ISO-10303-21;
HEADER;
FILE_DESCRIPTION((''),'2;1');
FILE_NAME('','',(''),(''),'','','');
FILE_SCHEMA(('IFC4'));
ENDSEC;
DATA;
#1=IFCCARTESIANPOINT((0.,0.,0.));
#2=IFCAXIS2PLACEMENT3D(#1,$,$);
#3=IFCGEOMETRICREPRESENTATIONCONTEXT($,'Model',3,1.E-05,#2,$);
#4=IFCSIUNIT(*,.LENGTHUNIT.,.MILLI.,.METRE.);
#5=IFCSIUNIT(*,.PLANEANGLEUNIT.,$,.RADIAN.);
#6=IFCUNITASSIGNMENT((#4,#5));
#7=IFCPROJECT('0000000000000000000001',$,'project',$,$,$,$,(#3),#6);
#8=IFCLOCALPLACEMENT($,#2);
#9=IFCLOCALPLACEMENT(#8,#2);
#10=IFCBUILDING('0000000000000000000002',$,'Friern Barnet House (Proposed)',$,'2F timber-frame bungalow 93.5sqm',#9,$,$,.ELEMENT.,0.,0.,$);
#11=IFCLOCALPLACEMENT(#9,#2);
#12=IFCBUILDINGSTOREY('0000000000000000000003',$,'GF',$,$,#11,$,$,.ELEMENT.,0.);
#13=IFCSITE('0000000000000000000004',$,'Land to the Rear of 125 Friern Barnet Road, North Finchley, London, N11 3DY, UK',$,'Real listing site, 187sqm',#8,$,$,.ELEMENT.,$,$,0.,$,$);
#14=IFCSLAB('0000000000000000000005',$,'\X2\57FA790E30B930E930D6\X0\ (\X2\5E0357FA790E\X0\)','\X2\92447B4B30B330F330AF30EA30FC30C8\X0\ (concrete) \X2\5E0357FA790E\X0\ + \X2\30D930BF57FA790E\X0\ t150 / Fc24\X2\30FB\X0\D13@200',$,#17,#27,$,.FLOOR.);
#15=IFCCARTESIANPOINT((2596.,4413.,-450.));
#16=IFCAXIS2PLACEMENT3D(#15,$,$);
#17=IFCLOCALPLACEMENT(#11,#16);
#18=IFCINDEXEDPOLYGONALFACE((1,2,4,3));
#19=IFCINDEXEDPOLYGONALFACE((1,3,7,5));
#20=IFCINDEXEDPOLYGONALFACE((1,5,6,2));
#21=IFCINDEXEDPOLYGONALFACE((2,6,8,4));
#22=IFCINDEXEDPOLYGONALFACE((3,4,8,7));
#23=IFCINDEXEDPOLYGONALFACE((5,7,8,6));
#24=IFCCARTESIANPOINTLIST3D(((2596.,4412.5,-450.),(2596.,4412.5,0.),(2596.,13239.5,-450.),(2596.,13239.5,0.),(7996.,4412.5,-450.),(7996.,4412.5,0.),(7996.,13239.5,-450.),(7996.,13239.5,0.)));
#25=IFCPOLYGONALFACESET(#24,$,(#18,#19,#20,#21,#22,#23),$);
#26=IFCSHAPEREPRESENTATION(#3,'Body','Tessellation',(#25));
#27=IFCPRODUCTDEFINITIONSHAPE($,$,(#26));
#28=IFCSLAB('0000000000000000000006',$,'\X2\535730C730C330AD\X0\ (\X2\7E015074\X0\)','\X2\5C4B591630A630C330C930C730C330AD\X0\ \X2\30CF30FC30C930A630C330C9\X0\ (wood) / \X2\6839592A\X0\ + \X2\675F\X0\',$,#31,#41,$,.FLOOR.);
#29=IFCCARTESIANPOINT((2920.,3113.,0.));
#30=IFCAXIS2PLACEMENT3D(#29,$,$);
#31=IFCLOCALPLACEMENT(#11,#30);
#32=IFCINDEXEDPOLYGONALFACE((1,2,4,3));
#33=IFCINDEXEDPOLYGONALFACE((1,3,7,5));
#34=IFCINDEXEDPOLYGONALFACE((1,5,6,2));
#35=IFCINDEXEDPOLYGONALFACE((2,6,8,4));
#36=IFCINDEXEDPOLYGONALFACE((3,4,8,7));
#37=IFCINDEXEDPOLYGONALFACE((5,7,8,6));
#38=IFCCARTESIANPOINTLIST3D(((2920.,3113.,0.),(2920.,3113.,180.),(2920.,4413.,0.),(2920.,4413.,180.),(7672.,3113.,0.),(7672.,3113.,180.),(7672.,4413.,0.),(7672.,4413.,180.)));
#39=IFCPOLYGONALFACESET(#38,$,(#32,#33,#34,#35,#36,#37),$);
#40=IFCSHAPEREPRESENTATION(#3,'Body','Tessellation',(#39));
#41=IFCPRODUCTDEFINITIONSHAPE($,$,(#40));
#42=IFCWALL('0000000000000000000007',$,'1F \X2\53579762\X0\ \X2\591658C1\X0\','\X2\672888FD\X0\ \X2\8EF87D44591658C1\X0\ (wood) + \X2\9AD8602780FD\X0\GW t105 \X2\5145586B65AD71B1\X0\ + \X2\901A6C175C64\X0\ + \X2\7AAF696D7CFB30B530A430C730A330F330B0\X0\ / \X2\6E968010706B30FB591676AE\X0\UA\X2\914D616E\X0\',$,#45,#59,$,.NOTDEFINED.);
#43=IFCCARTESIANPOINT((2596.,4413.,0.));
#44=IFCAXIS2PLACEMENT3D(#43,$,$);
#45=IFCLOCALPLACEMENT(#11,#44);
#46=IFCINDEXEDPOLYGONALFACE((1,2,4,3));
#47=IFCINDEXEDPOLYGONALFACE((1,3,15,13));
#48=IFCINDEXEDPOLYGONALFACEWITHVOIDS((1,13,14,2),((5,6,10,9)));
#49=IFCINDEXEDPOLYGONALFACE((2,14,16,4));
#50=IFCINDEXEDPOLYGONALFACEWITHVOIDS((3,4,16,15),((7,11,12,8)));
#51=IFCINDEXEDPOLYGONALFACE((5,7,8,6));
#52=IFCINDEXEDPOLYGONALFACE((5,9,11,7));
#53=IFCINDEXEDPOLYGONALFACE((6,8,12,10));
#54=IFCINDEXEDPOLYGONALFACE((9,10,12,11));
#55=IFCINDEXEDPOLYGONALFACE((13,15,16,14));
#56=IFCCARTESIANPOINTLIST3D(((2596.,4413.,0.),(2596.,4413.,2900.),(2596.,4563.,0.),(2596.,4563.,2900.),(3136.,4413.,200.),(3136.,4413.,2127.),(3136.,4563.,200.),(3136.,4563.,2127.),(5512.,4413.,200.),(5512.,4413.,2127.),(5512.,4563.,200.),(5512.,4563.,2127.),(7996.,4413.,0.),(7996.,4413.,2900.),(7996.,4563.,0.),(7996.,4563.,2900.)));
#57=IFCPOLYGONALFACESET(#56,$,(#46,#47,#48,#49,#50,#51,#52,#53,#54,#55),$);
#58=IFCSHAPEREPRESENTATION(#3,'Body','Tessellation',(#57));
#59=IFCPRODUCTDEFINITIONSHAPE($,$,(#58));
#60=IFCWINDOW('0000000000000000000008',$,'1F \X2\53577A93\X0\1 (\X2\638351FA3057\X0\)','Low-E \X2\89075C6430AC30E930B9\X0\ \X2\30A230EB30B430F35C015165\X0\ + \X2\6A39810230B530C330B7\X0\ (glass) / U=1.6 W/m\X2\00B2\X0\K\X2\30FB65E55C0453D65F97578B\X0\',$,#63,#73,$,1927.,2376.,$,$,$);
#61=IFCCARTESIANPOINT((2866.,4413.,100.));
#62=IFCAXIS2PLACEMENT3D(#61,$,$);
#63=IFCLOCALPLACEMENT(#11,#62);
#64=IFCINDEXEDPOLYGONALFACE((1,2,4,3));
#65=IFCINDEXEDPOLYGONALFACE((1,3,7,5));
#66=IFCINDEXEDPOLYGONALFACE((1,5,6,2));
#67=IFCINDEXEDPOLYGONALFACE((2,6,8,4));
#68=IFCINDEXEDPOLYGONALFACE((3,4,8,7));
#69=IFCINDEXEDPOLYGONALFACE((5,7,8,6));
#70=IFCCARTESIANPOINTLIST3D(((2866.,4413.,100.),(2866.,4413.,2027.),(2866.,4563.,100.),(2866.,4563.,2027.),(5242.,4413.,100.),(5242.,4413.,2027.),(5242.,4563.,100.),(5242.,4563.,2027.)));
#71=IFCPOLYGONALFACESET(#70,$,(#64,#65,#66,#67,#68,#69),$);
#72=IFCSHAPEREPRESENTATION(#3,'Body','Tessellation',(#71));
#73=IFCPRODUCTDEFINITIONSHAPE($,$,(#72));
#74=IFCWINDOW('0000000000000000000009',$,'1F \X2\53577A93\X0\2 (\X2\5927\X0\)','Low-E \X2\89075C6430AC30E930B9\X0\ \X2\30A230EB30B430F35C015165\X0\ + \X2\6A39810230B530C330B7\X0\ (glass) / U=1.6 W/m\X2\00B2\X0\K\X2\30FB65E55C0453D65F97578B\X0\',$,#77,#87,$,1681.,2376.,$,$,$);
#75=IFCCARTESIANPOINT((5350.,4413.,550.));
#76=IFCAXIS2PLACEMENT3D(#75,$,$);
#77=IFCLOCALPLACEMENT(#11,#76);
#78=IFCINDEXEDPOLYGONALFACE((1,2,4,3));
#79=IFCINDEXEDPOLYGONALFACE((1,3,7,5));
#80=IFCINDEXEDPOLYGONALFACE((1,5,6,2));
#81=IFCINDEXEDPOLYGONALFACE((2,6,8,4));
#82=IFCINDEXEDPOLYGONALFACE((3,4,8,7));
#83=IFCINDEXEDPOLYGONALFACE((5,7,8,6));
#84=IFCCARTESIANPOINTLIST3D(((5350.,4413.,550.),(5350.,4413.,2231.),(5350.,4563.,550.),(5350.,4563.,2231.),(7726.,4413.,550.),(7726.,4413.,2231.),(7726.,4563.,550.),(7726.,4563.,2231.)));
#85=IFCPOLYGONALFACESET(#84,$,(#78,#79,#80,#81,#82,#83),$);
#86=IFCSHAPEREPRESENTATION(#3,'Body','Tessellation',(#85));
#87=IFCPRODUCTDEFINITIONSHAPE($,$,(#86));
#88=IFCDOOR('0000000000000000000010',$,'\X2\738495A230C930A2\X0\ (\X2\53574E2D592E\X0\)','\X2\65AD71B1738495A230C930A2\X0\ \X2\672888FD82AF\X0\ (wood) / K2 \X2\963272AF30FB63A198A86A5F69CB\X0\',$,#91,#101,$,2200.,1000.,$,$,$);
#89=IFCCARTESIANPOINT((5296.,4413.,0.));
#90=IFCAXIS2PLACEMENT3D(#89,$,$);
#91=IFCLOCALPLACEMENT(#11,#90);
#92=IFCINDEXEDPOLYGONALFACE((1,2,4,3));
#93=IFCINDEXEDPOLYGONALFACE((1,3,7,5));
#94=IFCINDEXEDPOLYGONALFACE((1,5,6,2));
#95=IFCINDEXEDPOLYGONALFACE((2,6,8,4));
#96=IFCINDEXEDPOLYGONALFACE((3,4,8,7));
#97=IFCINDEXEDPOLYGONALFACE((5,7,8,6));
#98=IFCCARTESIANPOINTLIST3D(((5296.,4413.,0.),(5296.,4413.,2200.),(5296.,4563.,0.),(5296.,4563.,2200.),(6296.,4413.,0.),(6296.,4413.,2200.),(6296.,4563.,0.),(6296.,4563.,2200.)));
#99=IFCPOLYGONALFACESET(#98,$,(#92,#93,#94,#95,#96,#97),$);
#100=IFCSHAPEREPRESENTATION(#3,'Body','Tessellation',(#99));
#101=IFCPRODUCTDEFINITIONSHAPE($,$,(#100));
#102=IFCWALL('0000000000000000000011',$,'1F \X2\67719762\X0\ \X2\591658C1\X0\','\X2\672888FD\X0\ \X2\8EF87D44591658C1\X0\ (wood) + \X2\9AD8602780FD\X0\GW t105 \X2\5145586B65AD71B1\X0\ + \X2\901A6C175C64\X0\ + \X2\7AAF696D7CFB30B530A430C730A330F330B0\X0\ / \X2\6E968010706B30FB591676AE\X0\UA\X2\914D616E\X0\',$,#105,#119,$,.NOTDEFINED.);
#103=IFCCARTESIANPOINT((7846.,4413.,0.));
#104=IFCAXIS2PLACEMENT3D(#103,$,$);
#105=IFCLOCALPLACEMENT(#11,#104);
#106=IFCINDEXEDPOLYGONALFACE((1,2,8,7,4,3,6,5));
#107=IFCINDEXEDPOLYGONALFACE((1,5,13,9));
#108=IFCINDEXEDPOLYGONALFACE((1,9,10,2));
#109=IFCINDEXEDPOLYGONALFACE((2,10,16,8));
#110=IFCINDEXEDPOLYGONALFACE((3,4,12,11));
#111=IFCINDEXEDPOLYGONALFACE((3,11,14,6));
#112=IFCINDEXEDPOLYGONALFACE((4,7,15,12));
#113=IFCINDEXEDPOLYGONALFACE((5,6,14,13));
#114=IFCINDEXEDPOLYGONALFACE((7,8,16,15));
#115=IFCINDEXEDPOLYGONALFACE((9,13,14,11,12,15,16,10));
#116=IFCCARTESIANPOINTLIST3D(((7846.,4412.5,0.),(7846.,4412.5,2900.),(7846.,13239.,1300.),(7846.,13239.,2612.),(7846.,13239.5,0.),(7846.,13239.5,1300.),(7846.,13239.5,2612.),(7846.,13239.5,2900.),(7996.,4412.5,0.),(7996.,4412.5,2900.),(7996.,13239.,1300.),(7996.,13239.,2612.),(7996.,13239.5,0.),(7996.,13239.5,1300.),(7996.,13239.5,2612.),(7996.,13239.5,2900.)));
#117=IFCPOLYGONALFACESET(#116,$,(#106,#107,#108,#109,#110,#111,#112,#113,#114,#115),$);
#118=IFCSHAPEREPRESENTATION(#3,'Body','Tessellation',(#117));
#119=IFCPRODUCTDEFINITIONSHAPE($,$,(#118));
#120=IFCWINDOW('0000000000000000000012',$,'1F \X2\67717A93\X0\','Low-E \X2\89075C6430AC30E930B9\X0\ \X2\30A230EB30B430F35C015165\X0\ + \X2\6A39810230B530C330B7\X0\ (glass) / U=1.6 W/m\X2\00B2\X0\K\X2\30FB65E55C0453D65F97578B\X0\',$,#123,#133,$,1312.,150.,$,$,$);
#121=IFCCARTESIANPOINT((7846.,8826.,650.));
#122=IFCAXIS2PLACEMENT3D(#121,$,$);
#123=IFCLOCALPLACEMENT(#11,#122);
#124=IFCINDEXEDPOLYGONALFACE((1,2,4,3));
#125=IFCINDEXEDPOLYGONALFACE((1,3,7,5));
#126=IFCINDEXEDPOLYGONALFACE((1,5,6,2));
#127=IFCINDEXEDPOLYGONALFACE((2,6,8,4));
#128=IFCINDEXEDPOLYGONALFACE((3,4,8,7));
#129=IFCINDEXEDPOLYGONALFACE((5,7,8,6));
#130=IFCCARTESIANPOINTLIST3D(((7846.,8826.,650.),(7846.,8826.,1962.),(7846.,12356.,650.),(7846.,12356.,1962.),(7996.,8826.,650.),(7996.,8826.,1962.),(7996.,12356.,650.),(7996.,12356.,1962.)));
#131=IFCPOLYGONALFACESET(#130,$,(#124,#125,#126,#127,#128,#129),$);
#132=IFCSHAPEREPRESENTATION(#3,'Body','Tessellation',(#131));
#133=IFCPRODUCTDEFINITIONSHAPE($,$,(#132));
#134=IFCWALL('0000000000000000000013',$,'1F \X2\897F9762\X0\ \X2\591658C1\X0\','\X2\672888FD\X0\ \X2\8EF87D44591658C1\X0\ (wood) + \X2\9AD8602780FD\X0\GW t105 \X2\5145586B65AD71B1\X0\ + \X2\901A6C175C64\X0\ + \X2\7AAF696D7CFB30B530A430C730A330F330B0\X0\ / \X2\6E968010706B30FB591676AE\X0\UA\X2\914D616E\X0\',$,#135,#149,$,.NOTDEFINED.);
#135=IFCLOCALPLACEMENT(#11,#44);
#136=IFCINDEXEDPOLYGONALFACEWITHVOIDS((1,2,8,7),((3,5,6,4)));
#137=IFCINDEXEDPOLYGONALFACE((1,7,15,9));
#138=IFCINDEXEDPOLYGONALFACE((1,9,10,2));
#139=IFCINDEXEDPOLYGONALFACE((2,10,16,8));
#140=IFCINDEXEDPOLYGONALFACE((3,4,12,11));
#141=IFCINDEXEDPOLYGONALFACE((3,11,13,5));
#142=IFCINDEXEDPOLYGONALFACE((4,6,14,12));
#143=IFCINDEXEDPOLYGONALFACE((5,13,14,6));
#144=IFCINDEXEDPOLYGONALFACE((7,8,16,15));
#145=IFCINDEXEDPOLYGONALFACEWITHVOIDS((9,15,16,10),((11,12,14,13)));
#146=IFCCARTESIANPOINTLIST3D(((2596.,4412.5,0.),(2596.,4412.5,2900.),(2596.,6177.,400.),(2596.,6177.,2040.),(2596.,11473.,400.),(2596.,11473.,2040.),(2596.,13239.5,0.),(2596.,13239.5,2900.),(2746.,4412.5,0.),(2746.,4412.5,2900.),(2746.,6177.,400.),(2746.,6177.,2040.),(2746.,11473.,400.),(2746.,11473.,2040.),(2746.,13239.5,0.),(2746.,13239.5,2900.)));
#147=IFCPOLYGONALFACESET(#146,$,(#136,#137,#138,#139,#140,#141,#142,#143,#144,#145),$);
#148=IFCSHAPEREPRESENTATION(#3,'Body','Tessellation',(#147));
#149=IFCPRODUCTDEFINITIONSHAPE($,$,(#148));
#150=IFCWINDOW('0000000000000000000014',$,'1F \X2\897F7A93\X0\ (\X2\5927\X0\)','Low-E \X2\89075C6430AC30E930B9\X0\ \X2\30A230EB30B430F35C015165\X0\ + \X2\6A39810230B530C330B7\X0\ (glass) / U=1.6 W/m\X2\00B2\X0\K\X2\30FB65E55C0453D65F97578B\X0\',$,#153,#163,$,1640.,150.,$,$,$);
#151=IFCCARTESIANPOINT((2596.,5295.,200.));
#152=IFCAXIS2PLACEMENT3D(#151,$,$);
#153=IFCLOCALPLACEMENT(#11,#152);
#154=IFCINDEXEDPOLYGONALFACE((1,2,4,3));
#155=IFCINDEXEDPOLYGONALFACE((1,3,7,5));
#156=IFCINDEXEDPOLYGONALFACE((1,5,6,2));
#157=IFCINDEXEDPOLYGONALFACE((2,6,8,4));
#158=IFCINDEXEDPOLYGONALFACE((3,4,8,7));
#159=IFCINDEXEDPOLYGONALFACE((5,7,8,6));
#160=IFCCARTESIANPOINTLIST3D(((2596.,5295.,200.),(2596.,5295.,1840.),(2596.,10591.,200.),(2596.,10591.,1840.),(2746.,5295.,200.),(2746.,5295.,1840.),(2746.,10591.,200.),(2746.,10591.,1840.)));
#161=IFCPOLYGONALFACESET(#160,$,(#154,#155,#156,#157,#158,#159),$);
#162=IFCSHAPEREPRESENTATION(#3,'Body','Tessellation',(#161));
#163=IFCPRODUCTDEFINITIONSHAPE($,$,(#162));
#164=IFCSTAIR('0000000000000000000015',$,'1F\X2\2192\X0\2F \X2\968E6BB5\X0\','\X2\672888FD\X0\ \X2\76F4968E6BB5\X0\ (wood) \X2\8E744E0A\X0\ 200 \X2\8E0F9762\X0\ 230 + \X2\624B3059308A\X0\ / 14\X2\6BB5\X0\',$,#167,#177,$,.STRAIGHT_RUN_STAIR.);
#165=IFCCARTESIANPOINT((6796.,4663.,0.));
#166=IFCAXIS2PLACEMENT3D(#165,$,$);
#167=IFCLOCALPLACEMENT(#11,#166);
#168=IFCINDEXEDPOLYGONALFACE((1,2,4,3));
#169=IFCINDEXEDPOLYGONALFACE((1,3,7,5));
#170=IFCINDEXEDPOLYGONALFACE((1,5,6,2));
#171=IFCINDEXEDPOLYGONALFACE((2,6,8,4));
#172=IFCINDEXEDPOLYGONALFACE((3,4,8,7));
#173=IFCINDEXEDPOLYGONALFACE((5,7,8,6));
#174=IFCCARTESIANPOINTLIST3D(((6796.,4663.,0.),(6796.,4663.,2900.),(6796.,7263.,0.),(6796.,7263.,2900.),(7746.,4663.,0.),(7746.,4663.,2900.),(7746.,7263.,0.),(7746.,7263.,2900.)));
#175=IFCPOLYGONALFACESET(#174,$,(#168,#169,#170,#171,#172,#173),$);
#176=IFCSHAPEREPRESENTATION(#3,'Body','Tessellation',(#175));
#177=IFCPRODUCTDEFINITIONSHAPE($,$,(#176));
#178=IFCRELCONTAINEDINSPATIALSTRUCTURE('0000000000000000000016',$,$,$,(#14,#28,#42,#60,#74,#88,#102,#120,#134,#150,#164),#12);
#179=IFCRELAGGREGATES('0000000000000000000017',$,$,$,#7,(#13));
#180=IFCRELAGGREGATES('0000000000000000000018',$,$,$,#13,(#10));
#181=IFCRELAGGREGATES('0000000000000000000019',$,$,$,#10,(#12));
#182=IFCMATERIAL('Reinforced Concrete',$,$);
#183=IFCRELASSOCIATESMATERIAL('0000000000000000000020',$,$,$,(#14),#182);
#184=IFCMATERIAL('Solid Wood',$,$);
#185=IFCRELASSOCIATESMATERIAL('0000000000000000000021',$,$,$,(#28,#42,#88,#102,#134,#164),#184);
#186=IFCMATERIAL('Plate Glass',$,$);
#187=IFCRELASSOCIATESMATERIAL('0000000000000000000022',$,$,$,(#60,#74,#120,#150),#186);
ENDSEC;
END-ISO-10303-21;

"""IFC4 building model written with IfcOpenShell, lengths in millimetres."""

from ifc_helpers import new_model, si_unit, frame, frame_2d, origin, place, context, project, spatial, rectangle, extrude, material, element, fill, save


model = new_model("IFC4")

# Units and contexts
model_context = context("Model", 3, precision=1e-05, world=origin())
ifc_project = project(units=[si_unit("LENGTHUNIT", "METRE", prefix="MILLI"), si_unit("PLANEANGLEUNIT", "RADIAN")], contexts=[model_context])

# Site, building, storey
site_placement = place(None, origin())
site = spatial("IfcSite", under=ifc_project, at=site_placement, Name="Land to the Rear of 125 Friern Barnet Road, North Finchley, London, N11 3DY, UK", ObjectType="Real listing site, 187sqm", CompositionType="ELEMENT", RefElevation=0.0)
building_placement = place(site_placement, origin())
building = spatial("IfcBuilding", under=site, at=building_placement, Name="Friern Barnet House (Proposed)", ObjectType="2F timber-frame bungalow 93.5sqm", CompositionType="ELEMENT", ElevationOfRefHeight=0.0, ElevationOfTerrain=0.0)
storey_placement = place(building_placement, origin())
storey = spatial("IfcBuildingStorey", under=building, at=storey_placement, Name="GF", CompositionType="ELEMENT", Elevation=0.0)

# Slabs
ifc_material_1 = material(Name="Reinforced Concrete")
slab_1_placement = place(storey_placement, frame((2596.0, 4413.0, -450.0)))
element("IfcSlab", 1, at=slab_1_placement, inside=storey, material=ifc_material_1, Name="基礎スラブ (布基礎)", Description="鉄筋コンクリート (concrete) 布基礎 + ベタ基礎 t150 / Fc24・D13@200", PredefinedType="FLOOR", context=model_context, shape_type="SweptSolid", body=[
    extrude(rectangle(XDim=5400.0, YDim=8827.0, at=frame_2d((2700.0, 4413.0))), frame((2596.0, 4413.0, -450.0)), (0.0, 0.0, 1.0), 450.0),
])
ifc_material_2 = material(Name="Solid Wood")
slab_2_placement = place(storey_placement, frame((2920.0, 3113.0, 0.0)))
element("IfcSlab", 2, at=slab_2_placement, inside=storey, material=ifc_material_2, Name="南デッキ (縁側)", Description="屋外ウッドデッキ ハードウッド (wood) / 根太 + 束", PredefinedType="FLOOR", context=model_context, shape_type="SweptSolid", body=[
    extrude(rectangle(XDim=4752.0, YDim=1300.0, at=frame_2d((2376.0, 650.0))), frame((2920.0, 3113.0, 0.0)), (0.0, 0.0, 1.0), 180.0),
])

# Wall, openings, windows, door
wall_1_placement = place(storey_placement, frame((2596.0, 4413.0, 0.0)))
wall_1 = element("IfcWall", 3, at=wall_1_placement, inside=storey, material=ifc_material_2, Name="1F 南面 外壁", Description="木製 軸組外壁 (wood) + 高性能GW t105 充填断熱 + 通気層 + 窯業系サイディング / 準耐火・外皮UA配慮", PredefinedType="NOTDEFINED", context=model_context, shape_type="SweptSolid", body=[
    extrude(rectangle(XDim=5400.0, YDim=150.0, at=frame_2d((2700.0, 75.0))), frame((2596.0, 4413.0, 0.0)), (0.0, 0.0, 1.0), 2900.0),
])
opening_1_placement = place(storey_placement, frame((2866.0, 4413.0, 100.0)))
opening_1 = element("IfcOpeningElement", 4, at=opening_1_placement, cuts=wall_1, PredefinedType="NOTDEFINED", context=model_context, shape_type="SweptSolid", body=[
    extrude(rectangle(XDim=2376.0, YDim=150.0, at=frame_2d((1188.0, 75.0))), frame((2866.0, 4413.0, 100.0)), (0.0, 0.0, 1.0), 1927.0),
])
opening_2_placement = place(storey_placement, frame((5350.0, 4413.0, 550.0)))
opening_2 = element("IfcOpeningElement", 5, at=opening_2_placement, cuts=wall_1, PredefinedType="NOTDEFINED", context=model_context, shape_type="SweptSolid", body=[
    extrude(rectangle(XDim=2376.0, YDim=150.0, at=frame_2d((1188.0, 75.0))), frame((5350.0, 4413.0, 550.0)), (0.0, 0.0, 1.0), 1681.0),
])
opening_3_placement = place(storey_placement, frame((5296.0, 4413.0, 0.0)))
opening_3 = element("IfcOpeningElement", 6, at=opening_3_placement, cuts=wall_1, PredefinedType="NOTDEFINED", context=model_context, shape_type="SweptSolid", body=[
    extrude(rectangle(XDim=1000.0, YDim=150.0, at=frame_2d((500.0, 75.0))), frame((5296.0, 4413.0, 0.0)), (0.0, 0.0, 1.0), 2200.0),
])
ifc_material_3 = material(Name="Plate Glass")
window_1_placement = place(storey_placement, frame((2866.0, 4413.0, 100.0)))
window_1 = element("IfcWindow", 7, at=window_1_placement, inside=storey, material=ifc_material_3, Name="1F 南窓1 (掃出し)", Description="Low-E 複層ガラス アルゴン封入 + 樹脂サッシ (glass) / U=1.6 W/m²K・日射取得型", OverallHeight=1927.0, OverallWidth=2376.0, context=model_context, shape_type="SweptSolid", body=[
    extrude(rectangle(XDim=2376.0, YDim=150.0, at=frame_2d((1188.0, 75.0))), frame((2866.0, 4413.0, 100.0)), (0.0, 0.0, 1.0), 1927.0),
])
fill(opening_1, window_1)
window_2_placement = place(storey_placement, frame((5350.0, 4413.0, 550.0)))
window_2 = element("IfcWindow", 8, at=window_2_placement, inside=storey, material=ifc_material_3, Name="1F 南窓2 (大)", Description="Low-E 複層ガラス アルゴン封入 + 樹脂サッシ (glass) / U=1.6 W/m²K・日射取得型", OverallHeight=1681.0, OverallWidth=2376.0, context=model_context, shape_type="SweptSolid", body=[
    extrude(rectangle(XDim=2376.0, YDim=150.0, at=frame_2d((1188.0, 75.0))), frame((5350.0, 4413.0, 550.0)), (0.0, 0.0, 1.0), 1681.0),
])
fill(opening_2, window_2)
door_placement = place(storey_placement, frame((5296.0, 4413.0, 0.0)))
door = element("IfcDoor", 9, at=door_placement, inside=storey, material=ifc_material_2, Name="玄関ドア (南中央)", Description="断熱玄関ドア 木製芯 (wood) / K2 防犯・採風機構", OverallHeight=2200.0, OverallWidth=1000.0, context=model_context, shape_type="SweptSolid", body=[
    extrude(rectangle(XDim=1000.0, YDim=150.0, at=frame_2d((500.0, 75.0))), frame((5296.0, 4413.0, 0.0)), (0.0, 0.0, 1.0), 2200.0),
])
fill(opening_3, door)

# Walls, openings, windows
wall_2_placement = place(storey_placement, frame((7846.0, 4413.0, 0.0)))
wall_2 = element("IfcWall", 10, at=wall_2_placement, inside=storey, material=ifc_material_2, Name="1F 東面 外壁", Description="木製 軸組外壁 (wood) + 高性能GW t105 充填断熱 + 通気層 + 窯業系サイディング / 準耐火・外皮UA配慮", PredefinedType="NOTDEFINED", context=model_context, shape_type="SweptSolid", body=[
    extrude(rectangle(XDim=150.0, YDim=8827.0, at=frame_2d((75.0, 4413.0))), frame((7846.0, 4413.0, 0.0)), (0.0, 0.0, 1.0), 2900.0),
])
opening_4_placement = place(storey_placement, frame((7846.0, 8826.0, 650.0)))
opening_4 = element("IfcOpeningElement", 11, at=opening_4_placement, cuts=wall_2, PredefinedType="NOTDEFINED", context=model_context, shape_type="SweptSolid", body=[
    extrude(rectangle(XDim=150.0, YDim=3530.0, at=frame_2d((75.0, 1765.0))), frame((7846.0, 8826.0, 650.0)), (0.0, 0.0, 1.0), 1312.0),
])
window_3_placement = place(storey_placement, frame((7846.0, 8826.0, 650.0)))
window_3 = element("IfcWindow", 12, at=window_3_placement, inside=storey, material=ifc_material_3, Name="1F 東窓", Description="Low-E 複層ガラス アルゴン封入 + 樹脂サッシ (glass) / U=1.6 W/m²K・日射取得型", OverallHeight=1312.0, OverallWidth=150.0, context=model_context, shape_type="SweptSolid", body=[
    extrude(rectangle(XDim=150.0, YDim=3530.0, at=frame_2d((75.0, 1765.0))), frame((7846.0, 8826.0, 650.0)), (0.0, 0.0, 1.0), 1312.0),
])
fill(opening_4, window_3)
wall_3_placement = place(storey_placement, frame((2596.0, 4413.0, 0.0)))
wall_3 = element("IfcWall", 13, at=wall_3_placement, inside=storey, material=ifc_material_2, Name="1F 西面 外壁", Description="木製 軸組外壁 (wood) + 高性能GW t105 充填断熱 + 通気層 + 窯業系サイディング / 準耐火・外皮UA配慮", PredefinedType="NOTDEFINED", context=model_context, shape_type="SweptSolid", body=[
    extrude(rectangle(XDim=150.0, YDim=8827.0, at=frame_2d((75.0, 4413.0))), frame((2596.0, 4413.0, 0.0)), (0.0, 0.0, 1.0), 2900.0),
])
opening_5_placement = place(storey_placement, frame((2596.0, 5295.0, 200.0)))
opening_5 = element("IfcOpeningElement", 14, at=opening_5_placement, cuts=wall_3, PredefinedType="NOTDEFINED", context=model_context, shape_type="SweptSolid", body=[
    extrude(rectangle(XDim=150.0, YDim=5296.0, at=frame_2d((75.0, 2648.0))), frame((2596.0, 5295.0, 200.0)), (0.0, 0.0, 1.0), 1640.0),
])
window_4_placement = place(storey_placement, frame((2596.0, 5295.0, 200.0)))
window_4 = element("IfcWindow", 15, at=window_4_placement, inside=storey, material=ifc_material_3, Name="1F 西窓 (大)", Description="Low-E 複層ガラス アルゴン封入 + 樹脂サッシ (glass) / U=1.6 W/m²K・日射取得型", OverallHeight=1640.0, OverallWidth=150.0, context=model_context, shape_type="SweptSolid", body=[
    extrude(rectangle(XDim=150.0, YDim=5296.0, at=frame_2d((75.0, 2648.0))), frame((2596.0, 5295.0, 200.0)), (0.0, 0.0, 1.0), 1640.0),
])
fill(opening_5, window_4)

# Stair
stair_placement = place(storey_placement, frame((6796.0, 4663.0, 0.0)))
element("IfcStair", 16, at=stair_placement, inside=storey, material=ifc_material_2, Name="1F→2F 階段", Description="木製 直階段 (wood) 蹴上 200 踏面 230 + 手すり / 14段", PredefinedType="STRAIGHT_RUN_STAIR", context=model_context, shape_type="SweptSolid", body=[
    extrude(rectangle(XDim=950.0, YDim=2600.0, at=frame_2d((475.0, 1300.0))), frame((6796.0, 4663.0, 0.0)), (0.0, 0.0, 1.0), 2900.0),
])

save(model, "model.ifc")
